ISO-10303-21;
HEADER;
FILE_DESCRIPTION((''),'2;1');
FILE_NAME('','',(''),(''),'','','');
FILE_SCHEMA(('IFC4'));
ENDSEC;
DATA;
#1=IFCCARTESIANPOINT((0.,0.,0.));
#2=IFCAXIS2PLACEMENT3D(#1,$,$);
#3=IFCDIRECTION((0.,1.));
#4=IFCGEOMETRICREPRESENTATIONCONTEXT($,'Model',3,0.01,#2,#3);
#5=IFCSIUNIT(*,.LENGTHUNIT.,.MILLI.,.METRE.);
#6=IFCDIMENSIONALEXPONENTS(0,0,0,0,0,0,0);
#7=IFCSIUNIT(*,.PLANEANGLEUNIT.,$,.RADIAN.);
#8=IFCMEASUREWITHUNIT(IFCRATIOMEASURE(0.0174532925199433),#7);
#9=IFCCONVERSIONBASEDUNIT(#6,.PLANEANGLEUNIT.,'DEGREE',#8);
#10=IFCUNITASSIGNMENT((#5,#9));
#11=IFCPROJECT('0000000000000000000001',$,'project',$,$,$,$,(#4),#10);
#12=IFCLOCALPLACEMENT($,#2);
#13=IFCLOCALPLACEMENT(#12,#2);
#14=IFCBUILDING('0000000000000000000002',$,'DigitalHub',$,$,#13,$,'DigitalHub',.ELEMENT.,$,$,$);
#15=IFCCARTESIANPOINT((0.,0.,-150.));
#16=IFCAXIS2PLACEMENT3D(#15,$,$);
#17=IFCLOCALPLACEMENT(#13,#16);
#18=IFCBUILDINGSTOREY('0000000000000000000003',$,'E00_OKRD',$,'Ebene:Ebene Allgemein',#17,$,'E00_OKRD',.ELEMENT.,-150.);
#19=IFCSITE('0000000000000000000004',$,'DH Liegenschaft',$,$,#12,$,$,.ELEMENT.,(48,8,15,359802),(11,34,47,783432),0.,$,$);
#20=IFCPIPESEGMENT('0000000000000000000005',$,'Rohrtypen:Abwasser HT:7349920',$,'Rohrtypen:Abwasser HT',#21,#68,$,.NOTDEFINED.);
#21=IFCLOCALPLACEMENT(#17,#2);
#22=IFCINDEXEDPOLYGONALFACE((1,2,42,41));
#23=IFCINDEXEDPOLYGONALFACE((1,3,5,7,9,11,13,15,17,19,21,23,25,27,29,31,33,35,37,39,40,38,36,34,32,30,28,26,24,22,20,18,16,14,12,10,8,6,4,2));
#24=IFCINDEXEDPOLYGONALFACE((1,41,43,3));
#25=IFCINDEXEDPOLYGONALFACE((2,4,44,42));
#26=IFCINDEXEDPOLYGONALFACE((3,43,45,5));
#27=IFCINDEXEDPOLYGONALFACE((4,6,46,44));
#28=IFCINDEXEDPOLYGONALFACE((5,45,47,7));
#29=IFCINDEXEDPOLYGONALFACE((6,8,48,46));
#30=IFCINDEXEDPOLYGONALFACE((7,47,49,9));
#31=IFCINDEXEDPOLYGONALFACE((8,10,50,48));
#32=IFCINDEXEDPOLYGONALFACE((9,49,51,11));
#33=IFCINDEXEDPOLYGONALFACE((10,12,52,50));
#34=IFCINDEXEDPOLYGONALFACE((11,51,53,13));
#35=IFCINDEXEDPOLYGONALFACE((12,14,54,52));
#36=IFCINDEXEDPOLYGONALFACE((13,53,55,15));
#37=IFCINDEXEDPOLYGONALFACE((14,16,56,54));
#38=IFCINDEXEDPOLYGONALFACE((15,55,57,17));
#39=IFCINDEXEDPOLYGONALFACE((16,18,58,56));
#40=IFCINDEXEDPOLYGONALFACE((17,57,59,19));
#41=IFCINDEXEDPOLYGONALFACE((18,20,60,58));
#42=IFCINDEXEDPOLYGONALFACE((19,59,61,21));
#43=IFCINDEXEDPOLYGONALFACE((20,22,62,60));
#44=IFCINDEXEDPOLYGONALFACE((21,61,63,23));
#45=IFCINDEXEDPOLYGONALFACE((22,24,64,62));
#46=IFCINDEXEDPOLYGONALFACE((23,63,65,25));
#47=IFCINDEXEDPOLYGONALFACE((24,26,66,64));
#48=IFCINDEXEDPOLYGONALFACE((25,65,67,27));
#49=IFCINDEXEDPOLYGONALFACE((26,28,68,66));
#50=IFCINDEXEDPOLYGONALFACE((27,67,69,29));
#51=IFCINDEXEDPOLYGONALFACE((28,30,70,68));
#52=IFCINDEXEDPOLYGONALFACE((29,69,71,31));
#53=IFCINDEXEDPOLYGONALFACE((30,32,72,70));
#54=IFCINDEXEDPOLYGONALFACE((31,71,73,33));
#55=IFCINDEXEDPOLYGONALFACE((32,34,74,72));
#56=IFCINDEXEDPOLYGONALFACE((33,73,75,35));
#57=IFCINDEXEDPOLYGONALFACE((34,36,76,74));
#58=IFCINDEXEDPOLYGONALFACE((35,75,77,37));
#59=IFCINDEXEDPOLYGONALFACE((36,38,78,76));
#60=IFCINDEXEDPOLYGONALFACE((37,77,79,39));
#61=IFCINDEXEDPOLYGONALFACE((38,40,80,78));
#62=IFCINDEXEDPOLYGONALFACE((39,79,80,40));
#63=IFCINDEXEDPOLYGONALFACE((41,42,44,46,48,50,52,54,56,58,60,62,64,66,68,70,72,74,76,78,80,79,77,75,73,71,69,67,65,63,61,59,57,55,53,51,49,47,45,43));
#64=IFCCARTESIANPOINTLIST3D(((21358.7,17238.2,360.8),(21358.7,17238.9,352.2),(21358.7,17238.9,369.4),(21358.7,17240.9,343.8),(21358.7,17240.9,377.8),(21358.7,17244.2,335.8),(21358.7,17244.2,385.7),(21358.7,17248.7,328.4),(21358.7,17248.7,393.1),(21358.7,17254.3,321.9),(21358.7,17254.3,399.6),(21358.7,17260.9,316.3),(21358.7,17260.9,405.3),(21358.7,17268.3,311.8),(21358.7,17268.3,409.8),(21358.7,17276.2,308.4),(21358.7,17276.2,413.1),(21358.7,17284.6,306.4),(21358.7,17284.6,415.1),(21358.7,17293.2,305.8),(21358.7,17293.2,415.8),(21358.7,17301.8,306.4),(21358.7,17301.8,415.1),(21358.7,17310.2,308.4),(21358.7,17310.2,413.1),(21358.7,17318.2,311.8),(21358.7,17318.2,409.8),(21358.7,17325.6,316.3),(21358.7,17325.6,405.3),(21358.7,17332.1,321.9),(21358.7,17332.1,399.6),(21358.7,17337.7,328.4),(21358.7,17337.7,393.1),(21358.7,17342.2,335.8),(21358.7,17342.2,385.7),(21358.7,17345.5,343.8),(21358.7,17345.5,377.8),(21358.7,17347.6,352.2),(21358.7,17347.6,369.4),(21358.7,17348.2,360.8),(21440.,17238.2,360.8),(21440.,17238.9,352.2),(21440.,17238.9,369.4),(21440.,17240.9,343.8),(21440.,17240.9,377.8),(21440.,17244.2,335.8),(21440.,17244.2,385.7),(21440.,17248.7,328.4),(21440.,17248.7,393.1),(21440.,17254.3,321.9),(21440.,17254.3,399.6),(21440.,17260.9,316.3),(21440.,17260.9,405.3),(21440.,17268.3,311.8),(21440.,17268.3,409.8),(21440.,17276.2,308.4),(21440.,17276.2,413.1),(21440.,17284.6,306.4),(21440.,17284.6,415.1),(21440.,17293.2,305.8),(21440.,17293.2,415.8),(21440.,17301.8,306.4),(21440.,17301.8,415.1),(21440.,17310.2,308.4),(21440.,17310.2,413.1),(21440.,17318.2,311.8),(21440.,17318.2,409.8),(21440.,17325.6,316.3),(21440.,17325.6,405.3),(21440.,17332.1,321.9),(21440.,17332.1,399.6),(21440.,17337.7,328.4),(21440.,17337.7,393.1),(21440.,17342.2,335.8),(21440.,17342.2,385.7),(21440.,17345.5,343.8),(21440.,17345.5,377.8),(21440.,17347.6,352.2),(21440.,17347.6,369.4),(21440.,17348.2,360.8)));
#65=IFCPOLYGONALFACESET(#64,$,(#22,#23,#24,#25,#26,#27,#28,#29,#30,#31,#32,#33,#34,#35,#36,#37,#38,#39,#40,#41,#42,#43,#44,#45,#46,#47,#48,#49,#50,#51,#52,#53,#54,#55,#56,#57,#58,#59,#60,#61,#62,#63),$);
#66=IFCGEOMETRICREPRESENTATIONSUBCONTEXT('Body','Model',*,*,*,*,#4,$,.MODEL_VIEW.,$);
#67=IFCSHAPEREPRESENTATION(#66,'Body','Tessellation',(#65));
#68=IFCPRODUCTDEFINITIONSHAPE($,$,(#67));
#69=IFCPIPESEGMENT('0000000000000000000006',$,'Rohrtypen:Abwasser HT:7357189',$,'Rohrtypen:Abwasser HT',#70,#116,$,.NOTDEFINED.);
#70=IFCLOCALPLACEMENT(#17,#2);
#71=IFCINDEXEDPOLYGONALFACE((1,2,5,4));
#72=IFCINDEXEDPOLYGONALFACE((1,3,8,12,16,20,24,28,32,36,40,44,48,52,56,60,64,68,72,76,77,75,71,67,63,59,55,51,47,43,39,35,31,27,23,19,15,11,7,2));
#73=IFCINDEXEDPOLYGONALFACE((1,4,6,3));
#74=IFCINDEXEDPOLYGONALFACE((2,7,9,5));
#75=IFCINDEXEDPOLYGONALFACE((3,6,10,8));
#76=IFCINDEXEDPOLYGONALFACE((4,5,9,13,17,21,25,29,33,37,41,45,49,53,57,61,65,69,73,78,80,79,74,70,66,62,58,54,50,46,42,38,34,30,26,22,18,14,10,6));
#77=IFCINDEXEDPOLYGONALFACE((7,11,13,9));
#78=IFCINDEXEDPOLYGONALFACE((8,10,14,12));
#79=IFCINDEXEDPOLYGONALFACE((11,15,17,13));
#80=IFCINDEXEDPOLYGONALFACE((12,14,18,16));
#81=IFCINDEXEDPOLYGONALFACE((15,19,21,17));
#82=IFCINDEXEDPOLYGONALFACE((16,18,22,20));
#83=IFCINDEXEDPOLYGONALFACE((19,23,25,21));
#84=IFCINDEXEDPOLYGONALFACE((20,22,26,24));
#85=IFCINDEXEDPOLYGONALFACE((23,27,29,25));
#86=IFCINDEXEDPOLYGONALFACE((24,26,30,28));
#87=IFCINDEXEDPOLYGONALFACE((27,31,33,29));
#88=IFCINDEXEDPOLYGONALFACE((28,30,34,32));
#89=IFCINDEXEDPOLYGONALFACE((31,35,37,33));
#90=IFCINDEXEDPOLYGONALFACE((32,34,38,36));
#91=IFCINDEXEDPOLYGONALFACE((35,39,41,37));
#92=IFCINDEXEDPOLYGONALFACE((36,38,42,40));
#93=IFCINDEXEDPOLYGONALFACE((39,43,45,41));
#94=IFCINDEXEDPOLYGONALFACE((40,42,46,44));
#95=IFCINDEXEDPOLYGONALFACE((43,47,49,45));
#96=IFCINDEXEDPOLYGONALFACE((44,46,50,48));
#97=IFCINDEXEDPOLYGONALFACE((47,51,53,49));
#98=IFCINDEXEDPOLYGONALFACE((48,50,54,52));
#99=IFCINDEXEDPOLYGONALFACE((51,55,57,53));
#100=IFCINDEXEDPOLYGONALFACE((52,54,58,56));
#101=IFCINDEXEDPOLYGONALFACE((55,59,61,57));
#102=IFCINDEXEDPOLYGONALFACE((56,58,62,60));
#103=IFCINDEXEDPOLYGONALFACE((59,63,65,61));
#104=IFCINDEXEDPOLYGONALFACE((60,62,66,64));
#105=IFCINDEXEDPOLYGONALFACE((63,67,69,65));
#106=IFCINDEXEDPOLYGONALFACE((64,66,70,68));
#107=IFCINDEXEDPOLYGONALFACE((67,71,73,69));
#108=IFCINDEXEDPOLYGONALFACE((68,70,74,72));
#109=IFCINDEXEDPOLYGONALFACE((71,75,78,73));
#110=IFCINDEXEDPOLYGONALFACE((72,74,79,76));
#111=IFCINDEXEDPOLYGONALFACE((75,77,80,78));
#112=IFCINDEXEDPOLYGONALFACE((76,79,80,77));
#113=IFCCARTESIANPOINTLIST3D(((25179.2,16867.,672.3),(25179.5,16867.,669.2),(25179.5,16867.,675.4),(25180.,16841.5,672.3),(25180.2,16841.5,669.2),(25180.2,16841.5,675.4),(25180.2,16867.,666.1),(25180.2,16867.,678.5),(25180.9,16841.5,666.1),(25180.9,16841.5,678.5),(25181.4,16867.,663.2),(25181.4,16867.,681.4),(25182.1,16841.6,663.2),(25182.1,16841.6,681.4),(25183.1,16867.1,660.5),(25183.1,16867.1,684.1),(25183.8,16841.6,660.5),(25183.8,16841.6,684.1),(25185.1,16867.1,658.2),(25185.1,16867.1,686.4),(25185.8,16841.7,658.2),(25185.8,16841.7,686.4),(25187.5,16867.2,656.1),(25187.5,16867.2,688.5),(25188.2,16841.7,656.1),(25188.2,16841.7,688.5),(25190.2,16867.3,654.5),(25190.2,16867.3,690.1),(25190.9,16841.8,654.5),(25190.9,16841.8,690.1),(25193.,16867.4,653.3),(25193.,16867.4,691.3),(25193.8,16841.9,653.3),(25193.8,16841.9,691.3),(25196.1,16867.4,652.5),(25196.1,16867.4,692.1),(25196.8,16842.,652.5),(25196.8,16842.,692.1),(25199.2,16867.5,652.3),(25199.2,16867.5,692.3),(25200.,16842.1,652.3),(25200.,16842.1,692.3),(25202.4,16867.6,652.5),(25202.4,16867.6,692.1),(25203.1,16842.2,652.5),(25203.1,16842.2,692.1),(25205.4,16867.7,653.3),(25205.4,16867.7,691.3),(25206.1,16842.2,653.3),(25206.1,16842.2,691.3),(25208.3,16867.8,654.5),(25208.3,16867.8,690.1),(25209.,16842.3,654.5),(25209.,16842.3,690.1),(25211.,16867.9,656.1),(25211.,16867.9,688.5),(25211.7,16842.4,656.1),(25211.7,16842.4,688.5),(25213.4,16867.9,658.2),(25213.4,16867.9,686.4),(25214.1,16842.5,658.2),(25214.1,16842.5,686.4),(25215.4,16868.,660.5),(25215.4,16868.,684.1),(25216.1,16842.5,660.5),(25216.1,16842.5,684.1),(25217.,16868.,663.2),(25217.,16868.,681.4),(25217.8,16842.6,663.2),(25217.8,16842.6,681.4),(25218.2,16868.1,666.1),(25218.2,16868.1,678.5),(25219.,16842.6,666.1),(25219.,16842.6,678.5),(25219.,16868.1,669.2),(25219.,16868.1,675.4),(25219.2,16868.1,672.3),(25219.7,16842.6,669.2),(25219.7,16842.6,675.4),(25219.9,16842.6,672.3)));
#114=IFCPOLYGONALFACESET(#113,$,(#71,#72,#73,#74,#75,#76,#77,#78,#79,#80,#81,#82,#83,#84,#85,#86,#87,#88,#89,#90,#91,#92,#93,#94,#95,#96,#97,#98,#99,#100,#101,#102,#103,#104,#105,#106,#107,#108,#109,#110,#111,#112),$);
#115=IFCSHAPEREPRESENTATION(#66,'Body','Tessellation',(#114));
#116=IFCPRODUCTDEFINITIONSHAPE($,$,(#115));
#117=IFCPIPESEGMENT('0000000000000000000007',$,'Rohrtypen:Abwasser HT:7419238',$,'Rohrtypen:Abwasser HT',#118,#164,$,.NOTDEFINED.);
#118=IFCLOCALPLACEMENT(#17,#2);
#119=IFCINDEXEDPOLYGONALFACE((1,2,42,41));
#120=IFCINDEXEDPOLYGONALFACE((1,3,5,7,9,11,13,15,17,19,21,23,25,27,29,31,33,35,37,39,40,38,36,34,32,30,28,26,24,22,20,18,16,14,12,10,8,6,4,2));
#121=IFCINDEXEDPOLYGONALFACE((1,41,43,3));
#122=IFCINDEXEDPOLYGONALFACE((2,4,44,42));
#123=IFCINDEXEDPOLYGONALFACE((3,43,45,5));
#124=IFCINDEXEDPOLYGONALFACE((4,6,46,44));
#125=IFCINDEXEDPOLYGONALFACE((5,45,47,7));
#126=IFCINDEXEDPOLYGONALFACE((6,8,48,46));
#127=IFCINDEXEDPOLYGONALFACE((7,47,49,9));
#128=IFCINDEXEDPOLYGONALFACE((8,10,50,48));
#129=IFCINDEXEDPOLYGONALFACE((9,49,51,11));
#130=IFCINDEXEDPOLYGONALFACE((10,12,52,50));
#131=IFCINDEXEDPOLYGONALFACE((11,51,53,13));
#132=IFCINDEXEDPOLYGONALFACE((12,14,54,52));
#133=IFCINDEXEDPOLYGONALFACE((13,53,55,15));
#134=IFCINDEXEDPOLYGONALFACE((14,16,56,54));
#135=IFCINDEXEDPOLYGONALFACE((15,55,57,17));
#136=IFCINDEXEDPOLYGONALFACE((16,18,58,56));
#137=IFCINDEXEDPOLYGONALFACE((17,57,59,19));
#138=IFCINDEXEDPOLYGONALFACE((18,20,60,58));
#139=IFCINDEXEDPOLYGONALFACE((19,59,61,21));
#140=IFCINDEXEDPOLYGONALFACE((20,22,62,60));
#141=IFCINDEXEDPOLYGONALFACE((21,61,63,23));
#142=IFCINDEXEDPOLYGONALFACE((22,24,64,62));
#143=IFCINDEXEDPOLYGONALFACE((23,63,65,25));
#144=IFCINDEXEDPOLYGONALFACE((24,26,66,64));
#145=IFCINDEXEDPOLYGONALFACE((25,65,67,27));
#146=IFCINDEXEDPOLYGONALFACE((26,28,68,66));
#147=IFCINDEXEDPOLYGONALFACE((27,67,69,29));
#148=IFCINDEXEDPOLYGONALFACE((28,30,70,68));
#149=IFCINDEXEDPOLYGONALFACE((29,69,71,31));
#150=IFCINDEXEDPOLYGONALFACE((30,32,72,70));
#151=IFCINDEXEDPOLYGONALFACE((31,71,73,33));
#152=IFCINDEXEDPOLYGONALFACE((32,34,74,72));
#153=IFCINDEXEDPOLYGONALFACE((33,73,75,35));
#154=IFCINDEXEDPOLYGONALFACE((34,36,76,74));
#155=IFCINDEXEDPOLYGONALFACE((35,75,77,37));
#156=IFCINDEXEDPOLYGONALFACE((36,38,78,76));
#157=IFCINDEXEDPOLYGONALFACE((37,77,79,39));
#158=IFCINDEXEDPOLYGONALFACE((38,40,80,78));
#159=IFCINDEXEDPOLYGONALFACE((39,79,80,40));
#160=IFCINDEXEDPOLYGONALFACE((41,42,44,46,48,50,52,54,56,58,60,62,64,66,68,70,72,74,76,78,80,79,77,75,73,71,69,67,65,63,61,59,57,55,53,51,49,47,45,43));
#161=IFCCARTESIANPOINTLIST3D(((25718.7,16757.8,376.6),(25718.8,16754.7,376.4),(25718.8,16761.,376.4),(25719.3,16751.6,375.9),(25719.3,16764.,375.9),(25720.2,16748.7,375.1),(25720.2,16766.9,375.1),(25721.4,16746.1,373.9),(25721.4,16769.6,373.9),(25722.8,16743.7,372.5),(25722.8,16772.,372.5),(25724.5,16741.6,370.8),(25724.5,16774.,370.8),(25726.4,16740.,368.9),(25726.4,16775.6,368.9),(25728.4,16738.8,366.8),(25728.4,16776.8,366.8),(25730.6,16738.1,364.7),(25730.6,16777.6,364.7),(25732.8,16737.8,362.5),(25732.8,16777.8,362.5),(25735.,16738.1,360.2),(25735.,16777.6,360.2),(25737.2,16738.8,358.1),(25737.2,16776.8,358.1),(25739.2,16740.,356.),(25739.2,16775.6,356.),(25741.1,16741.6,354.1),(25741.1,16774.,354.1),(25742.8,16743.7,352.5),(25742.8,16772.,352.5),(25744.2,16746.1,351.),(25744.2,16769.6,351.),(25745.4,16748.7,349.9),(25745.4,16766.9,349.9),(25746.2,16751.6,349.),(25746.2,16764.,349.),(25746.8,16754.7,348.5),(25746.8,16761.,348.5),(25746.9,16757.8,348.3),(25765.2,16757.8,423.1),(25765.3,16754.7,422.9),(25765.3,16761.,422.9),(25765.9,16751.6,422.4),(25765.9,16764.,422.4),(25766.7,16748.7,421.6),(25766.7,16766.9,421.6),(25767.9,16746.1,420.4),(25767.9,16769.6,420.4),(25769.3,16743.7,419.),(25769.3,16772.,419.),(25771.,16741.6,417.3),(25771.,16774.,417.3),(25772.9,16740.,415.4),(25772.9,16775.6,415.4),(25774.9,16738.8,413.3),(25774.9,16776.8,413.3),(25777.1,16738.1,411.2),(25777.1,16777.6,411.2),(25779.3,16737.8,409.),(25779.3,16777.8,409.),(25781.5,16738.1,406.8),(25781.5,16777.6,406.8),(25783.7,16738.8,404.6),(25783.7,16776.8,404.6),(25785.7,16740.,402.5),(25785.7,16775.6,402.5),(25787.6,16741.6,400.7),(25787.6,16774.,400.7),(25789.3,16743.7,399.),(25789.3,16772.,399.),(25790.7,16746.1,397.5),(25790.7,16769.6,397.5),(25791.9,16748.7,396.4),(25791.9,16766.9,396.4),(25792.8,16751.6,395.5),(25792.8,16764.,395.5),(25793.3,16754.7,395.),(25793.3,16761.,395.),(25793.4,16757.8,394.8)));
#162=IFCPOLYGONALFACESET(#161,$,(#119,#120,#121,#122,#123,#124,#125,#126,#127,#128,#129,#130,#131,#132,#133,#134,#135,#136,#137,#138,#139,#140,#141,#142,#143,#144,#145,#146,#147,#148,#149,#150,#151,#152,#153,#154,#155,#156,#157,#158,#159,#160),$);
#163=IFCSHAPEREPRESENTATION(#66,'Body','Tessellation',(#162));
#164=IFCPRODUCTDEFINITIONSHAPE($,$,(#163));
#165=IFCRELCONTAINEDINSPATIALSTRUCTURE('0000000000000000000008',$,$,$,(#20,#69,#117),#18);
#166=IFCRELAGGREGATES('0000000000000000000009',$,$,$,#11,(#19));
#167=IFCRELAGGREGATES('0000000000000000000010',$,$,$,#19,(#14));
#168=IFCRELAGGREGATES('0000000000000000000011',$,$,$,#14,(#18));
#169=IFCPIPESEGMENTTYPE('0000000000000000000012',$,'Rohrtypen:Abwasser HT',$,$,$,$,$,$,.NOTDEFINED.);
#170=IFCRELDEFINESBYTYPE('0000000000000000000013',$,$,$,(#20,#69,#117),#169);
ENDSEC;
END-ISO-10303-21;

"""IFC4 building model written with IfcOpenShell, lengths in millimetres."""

from ifc_helpers import new_model, entity, si_unit, converted_unit, direction, frame, origin, place, context, subcontext, project, spatial, indexed_curve, outline, extrude, type_object, element, save


model = new_model("IFC4")

# Units and contexts
model_context = context("Model", 3, precision=0.01, world=origin(), true_north=direction((0.0, 1.0)))
body_context = subcontext(model_context, "Body", "Model", "MODEL_VIEW")
ifc_project = project(units=[si_unit("LENGTHUNIT", "METRE", prefix="MILLI"), converted_unit("PLANEANGLEUNIT", "DEGREE", entity("IfcRatioMeasure", 0.0174532925199433), si_unit("PLANEANGLEUNIT", "RADIAN"), dimensions=[0, 0, 0, 0, 0, 0, 0])], contexts=[model_context])

# Site, building, storey
site_placement = place(None, origin())
site = spatial("IfcSite", under=ifc_project, at=site_placement, Name="DH Liegenschaft", CompositionType="ELEMENT", RefLatitude=(48, 8, 15, 359802), RefLongitude=(11, 34, 47, 783432), RefElevation=0.0)
building_placement = place(site_placement, origin())
building = spatial("IfcBuilding", under=site, at=building_placement, Name="DigitalHub", LongName="DigitalHub", CompositionType="ELEMENT")
storey_placement = place(building_placement, frame((0.0, 0.0, -150.0)))
storey = spatial("IfcBuildingStorey", under=building, at=storey_placement, Name="E00_OKRD", ObjectType="Ebene:Ebene Allgemein", LongName="E00_OKRD", CompositionType="ELEMENT", Elevation=-150.0)

# Pipe segments
pipe_segment_type_1 = type_object("IfcPipeSegmentType", Name="Rohrtypen:Abwasser HT", PredefinedType="NOTDEFINED")
pipe_segment_1_placement = place(storey_placement, frame((21358.7, 17236.6, 304.2)))
element("IfcPipeSegment", 1, at=pipe_segment_1_placement, inside=storey, type_object=pipe_segment_type_1, Name="Rohrtypen:Abwasser HT:7349920", ObjectType="Rohrtypen:Abwasser HT", PredefinedType="NOTDEFINED", context=body_context, shape_type="SweptSolid", body=[
    extrude(outline(indexed_curve([(55.0, 0.0), (54.3, 8.6), (52.3, 17.0), (49.0, 25.0), (44.5, 32.3), (38.9, 38.9), (32.3, 44.5), (25.0, 49.0), (17.0, 52.3), (8.6, 54.3), (0.0, 55.0), (-8.6, 54.3), (-17.0, 52.3), (-25.0, 49.0), (-32.3, 44.5), (-38.9, 38.9), (-44.5, 32.3), (-49.0, 25.0), (-52.3, 17.0), (-54.3, 8.6), (-55.0, 0.0), (-54.3, -8.6), (-52.3, -17.0), (-49.0, -25.0), (-44.5, -32.3), (-38.9, -38.9), (-32.3, -44.5), (-25.0, -49.0), (-17.0, -52.3), (-8.6, -54.3), (0.0, -55.0), (8.6, -54.3), (17.0, -52.3), (25.0, -49.0), (32.3, -44.5), (38.9, -38.9), (44.5, -32.3), (49.0, -25.0), (52.3, -17.0), (54.3, -8.6), (55.0, 0.0)], self_intersect=False)), frame((0.0, 56.6, 56.6), z_axis=(1.0, 0.0, 0.0), x_axis=(0.0, 1.0, 0.0)), (0.0, 0.0, 1.0), 81.3),
])
pipe_segment_2_placement = place(storey_placement, frame((25177.6, 16839.9, 650.7)))
element("IfcPipeSegment", 2, at=pipe_segment_2_placement, inside=storey, type_object=pipe_segment_type_1, Name="Rohrtypen:Abwasser HT:7357189", ObjectType="Rohrtypen:Abwasser HT", PredefinedType="NOTDEFINED", context=body_context, shape_type="SweptSolid", body=[
    extrude(outline(indexed_curve([(20.0, 0.0), (19.8, 3.1), (19.0, 6.2), (17.8, 9.1), (16.2, 11.8), (14.1, 14.1), (11.8, 16.2), (9.1, 17.8), (6.2, 19.0), (3.1, 19.8), (0.0, 20.0), (-3.1, 19.8), (-6.2, 19.0), (-9.1, 17.8), (-11.8, 16.2), (-14.1, 14.1), (-16.2, 11.8), (-17.8, 9.1), (-19.0, 6.2), (-19.8, 3.1), (-20.0, 0.0), (-19.8, -3.1), (-19.0, -6.2), (-17.8, -9.1), (-16.2, -11.8), (-14.1, -14.1), (-11.8, -16.2), (-9.1, -17.8), (-6.2, -19.0), (-3.1, -19.8), (0.0, -20.0), (3.1, -19.8), (6.2, -19.0), (9.1, -17.8), (11.8, -16.2), (14.1, -14.1), (16.2, -11.8), (17.8, -9.1), (19.0, -6.2), (19.8, -3.1), (20.0, 0.0)], self_intersect=False)), frame((21.6, 27.6, 21.6), z_axis=(0.02857, -0.999592, 0.0), x_axis=(-0.999592, -0.02857, 0.0)), (0.0, 0.0, 1.0), 25.5),
])
pipe_segment_3_placement = place(storey_placement, frame((25717.1, 16736.2, 346.7)))
element("IfcPipeSegment", 3, at=pipe_segment_3_placement, inside=storey, type_object=pipe_segment_type_1, Name="Rohrtypen:Abwasser HT:7419238", ObjectType="Rohrtypen:Abwasser HT", PredefinedType="NOTDEFINED", context=body_context, shape_type="SweptSolid", body=[
    extrude(outline(indexed_curve([(20.0, 0.0), (19.8, 3.1), (19.0, 6.2), (17.8, 9.1), (16.2, 11.8), (14.1, 14.1), (11.8, 16.2), (9.1, 17.8), (6.2, 19.0), (3.1, 19.8), (0.0, 20.0), (-3.1, 19.8), (-6.2, 19.0), (-9.1, 17.8), (-11.8, 16.2), (-14.1, 14.1), (-16.2, 11.8), (-17.8, 9.1), (-19.0, 6.2), (-19.8, 3.1), (-20.0, 0.0), (-19.8, -3.1), (-19.0, -6.2), (-17.8, -9.1), (-16.2, -11.8), (-14.1, -14.1), (-11.8, -16.2), (-9.1, -17.8), (-6.2, -19.0), (-3.1, -19.8), (0.0, -20.0), (3.1, -19.8), (6.2, -19.0), (9.1, -17.8), (11.8, -16.2), (14.1, -14.1), (16.2, -11.8), (17.8, -9.1), (19.0, -6.2), (19.8, -3.1), (20.0, 0.0)], self_intersect=False)), frame((15.7, 21.6, 15.7), z_axis=(0.707107, 0.0, 0.707107), x_axis=(0.0, -1.0, 0.0)), (0.0, 0.0, 1.0), 65.8),
])

save(model, "model.ifc")
